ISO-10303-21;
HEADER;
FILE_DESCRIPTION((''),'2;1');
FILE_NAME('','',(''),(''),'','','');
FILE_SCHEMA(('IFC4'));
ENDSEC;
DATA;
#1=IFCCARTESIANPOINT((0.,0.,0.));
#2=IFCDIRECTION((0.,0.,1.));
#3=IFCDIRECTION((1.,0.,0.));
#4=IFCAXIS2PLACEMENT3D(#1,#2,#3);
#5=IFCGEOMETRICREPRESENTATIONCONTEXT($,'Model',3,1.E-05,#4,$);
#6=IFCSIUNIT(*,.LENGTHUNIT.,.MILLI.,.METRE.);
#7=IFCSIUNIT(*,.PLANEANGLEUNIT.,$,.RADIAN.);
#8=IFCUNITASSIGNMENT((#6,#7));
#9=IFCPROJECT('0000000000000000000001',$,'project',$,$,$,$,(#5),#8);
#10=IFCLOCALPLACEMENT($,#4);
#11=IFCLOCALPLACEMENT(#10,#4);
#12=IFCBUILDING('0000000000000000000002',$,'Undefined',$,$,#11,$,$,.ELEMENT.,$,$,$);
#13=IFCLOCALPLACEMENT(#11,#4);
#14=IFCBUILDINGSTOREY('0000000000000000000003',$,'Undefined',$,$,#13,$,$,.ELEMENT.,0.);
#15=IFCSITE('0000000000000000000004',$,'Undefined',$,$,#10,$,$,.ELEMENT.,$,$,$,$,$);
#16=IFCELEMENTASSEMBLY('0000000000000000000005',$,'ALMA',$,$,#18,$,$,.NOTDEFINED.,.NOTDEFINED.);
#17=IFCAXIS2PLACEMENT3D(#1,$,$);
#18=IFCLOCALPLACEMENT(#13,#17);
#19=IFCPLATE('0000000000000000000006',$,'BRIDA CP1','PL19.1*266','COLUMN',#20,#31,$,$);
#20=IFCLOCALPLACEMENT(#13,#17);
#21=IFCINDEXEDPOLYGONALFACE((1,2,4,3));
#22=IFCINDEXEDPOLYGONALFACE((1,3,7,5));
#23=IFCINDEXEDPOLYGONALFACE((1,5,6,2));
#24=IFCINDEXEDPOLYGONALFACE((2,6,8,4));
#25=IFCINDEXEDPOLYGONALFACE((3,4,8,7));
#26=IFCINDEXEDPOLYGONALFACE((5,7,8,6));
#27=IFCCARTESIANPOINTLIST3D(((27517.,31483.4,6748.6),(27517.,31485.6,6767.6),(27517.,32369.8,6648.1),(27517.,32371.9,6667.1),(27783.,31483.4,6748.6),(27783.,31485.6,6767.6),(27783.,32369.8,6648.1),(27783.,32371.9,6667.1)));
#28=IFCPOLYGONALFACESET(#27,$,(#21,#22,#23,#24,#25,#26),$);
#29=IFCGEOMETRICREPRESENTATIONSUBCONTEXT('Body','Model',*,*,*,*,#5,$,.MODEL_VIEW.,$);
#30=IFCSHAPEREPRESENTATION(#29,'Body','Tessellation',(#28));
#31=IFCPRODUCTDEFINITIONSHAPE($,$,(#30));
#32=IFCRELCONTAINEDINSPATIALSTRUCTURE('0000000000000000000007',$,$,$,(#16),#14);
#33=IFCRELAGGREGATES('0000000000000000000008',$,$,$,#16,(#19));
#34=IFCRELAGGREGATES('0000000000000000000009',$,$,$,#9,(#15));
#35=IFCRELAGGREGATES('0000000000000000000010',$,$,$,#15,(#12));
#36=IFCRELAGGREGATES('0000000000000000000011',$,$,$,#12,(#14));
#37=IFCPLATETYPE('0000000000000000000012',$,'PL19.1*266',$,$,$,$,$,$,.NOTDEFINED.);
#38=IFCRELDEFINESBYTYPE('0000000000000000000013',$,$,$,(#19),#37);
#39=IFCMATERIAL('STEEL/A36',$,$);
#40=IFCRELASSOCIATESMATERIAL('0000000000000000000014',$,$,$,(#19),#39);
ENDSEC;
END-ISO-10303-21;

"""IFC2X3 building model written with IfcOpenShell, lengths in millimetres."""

from ifc_helpers import new_model, si_unit, frame, origin_with_axes, place, context, subcontext, project, spatial, polyline, outline, extrude, material, type_object, element, aggregate, save


model = new_model("IFC2X3")

# Units and contexts
model_context = context("Model", 3, precision=1e-05, world=origin_with_axes())
body_context = subcontext(model_context, "Body", "Model", "MODEL_VIEW")
ifc_project = project(units=[si_unit("LENGTHUNIT", "METRE", prefix="MILLI"), si_unit("PLANEANGLEUNIT", "RADIAN")], contexts=[model_context])

# Site, building, storey
site_placement = place(None, origin_with_axes())
site = spatial("IfcSite", under=ifc_project, at=site_placement, Name="Undefined", CompositionType="ELEMENT")
building_placement = place(site_placement, origin_with_axes())
building = spatial("IfcBuilding", under=site, at=building_placement, Name="Undefined", CompositionType="ELEMENT")
storey_placement = place(building_placement, origin_with_axes())
storey = spatial("IfcBuildingStorey", under=building, at=storey_placement, Name="Undefined", CompositionType="ELEMENT", Elevation=0.0)

# Element assembly
assembly_1_placement = place(storey_placement, origin_with_axes())
assembly_1 = element("IfcElementAssembly", 1, at=assembly_1_placement, inside=storey, Name="ALMA", AssemblyPlace="NOTDEFINED", PredefinedType="NOTDEFINED")

# Plate
ifc_material_1 = material(Name="STEEL/A36")
plate_type_1 = type_object("IfcPlateType", Name="PL19.1*266", PredefinedType="NOTDEFINED")
plate_1_placement = place(assembly_1_placement, frame((27650.0, 32370.8, 6657.6), z_axis=(0.0, -0.112642, -0.993636), x_axis=(0.0, -0.993636, 0.112642)))
plate_1 = element("IfcPlate", 2, at=plate_1_placement, type_object=plate_type_1, material=ifc_material_1, Name="BRIDA CP1", Description="PL19.1*266", ObjectType="COLUMN", context=body_context, shape_type="SweptSolid", body=[
    extrude(outline(polyline([(0.0, -133.0), (0.0, 133.0), (892.0, 133.0), (892.0, -133.0), (0.0, -133.0)])), frame((0.0, 0.0, -9.6), z_axis=(0.0, 0.0, 1.0), x_axis=(1.0, 0.0, 0.0)), (0.0, 0.0, 1.0), 19.1),
])

aggregate(assembly_1, [plate_1])

save(model, "model.ifc")
